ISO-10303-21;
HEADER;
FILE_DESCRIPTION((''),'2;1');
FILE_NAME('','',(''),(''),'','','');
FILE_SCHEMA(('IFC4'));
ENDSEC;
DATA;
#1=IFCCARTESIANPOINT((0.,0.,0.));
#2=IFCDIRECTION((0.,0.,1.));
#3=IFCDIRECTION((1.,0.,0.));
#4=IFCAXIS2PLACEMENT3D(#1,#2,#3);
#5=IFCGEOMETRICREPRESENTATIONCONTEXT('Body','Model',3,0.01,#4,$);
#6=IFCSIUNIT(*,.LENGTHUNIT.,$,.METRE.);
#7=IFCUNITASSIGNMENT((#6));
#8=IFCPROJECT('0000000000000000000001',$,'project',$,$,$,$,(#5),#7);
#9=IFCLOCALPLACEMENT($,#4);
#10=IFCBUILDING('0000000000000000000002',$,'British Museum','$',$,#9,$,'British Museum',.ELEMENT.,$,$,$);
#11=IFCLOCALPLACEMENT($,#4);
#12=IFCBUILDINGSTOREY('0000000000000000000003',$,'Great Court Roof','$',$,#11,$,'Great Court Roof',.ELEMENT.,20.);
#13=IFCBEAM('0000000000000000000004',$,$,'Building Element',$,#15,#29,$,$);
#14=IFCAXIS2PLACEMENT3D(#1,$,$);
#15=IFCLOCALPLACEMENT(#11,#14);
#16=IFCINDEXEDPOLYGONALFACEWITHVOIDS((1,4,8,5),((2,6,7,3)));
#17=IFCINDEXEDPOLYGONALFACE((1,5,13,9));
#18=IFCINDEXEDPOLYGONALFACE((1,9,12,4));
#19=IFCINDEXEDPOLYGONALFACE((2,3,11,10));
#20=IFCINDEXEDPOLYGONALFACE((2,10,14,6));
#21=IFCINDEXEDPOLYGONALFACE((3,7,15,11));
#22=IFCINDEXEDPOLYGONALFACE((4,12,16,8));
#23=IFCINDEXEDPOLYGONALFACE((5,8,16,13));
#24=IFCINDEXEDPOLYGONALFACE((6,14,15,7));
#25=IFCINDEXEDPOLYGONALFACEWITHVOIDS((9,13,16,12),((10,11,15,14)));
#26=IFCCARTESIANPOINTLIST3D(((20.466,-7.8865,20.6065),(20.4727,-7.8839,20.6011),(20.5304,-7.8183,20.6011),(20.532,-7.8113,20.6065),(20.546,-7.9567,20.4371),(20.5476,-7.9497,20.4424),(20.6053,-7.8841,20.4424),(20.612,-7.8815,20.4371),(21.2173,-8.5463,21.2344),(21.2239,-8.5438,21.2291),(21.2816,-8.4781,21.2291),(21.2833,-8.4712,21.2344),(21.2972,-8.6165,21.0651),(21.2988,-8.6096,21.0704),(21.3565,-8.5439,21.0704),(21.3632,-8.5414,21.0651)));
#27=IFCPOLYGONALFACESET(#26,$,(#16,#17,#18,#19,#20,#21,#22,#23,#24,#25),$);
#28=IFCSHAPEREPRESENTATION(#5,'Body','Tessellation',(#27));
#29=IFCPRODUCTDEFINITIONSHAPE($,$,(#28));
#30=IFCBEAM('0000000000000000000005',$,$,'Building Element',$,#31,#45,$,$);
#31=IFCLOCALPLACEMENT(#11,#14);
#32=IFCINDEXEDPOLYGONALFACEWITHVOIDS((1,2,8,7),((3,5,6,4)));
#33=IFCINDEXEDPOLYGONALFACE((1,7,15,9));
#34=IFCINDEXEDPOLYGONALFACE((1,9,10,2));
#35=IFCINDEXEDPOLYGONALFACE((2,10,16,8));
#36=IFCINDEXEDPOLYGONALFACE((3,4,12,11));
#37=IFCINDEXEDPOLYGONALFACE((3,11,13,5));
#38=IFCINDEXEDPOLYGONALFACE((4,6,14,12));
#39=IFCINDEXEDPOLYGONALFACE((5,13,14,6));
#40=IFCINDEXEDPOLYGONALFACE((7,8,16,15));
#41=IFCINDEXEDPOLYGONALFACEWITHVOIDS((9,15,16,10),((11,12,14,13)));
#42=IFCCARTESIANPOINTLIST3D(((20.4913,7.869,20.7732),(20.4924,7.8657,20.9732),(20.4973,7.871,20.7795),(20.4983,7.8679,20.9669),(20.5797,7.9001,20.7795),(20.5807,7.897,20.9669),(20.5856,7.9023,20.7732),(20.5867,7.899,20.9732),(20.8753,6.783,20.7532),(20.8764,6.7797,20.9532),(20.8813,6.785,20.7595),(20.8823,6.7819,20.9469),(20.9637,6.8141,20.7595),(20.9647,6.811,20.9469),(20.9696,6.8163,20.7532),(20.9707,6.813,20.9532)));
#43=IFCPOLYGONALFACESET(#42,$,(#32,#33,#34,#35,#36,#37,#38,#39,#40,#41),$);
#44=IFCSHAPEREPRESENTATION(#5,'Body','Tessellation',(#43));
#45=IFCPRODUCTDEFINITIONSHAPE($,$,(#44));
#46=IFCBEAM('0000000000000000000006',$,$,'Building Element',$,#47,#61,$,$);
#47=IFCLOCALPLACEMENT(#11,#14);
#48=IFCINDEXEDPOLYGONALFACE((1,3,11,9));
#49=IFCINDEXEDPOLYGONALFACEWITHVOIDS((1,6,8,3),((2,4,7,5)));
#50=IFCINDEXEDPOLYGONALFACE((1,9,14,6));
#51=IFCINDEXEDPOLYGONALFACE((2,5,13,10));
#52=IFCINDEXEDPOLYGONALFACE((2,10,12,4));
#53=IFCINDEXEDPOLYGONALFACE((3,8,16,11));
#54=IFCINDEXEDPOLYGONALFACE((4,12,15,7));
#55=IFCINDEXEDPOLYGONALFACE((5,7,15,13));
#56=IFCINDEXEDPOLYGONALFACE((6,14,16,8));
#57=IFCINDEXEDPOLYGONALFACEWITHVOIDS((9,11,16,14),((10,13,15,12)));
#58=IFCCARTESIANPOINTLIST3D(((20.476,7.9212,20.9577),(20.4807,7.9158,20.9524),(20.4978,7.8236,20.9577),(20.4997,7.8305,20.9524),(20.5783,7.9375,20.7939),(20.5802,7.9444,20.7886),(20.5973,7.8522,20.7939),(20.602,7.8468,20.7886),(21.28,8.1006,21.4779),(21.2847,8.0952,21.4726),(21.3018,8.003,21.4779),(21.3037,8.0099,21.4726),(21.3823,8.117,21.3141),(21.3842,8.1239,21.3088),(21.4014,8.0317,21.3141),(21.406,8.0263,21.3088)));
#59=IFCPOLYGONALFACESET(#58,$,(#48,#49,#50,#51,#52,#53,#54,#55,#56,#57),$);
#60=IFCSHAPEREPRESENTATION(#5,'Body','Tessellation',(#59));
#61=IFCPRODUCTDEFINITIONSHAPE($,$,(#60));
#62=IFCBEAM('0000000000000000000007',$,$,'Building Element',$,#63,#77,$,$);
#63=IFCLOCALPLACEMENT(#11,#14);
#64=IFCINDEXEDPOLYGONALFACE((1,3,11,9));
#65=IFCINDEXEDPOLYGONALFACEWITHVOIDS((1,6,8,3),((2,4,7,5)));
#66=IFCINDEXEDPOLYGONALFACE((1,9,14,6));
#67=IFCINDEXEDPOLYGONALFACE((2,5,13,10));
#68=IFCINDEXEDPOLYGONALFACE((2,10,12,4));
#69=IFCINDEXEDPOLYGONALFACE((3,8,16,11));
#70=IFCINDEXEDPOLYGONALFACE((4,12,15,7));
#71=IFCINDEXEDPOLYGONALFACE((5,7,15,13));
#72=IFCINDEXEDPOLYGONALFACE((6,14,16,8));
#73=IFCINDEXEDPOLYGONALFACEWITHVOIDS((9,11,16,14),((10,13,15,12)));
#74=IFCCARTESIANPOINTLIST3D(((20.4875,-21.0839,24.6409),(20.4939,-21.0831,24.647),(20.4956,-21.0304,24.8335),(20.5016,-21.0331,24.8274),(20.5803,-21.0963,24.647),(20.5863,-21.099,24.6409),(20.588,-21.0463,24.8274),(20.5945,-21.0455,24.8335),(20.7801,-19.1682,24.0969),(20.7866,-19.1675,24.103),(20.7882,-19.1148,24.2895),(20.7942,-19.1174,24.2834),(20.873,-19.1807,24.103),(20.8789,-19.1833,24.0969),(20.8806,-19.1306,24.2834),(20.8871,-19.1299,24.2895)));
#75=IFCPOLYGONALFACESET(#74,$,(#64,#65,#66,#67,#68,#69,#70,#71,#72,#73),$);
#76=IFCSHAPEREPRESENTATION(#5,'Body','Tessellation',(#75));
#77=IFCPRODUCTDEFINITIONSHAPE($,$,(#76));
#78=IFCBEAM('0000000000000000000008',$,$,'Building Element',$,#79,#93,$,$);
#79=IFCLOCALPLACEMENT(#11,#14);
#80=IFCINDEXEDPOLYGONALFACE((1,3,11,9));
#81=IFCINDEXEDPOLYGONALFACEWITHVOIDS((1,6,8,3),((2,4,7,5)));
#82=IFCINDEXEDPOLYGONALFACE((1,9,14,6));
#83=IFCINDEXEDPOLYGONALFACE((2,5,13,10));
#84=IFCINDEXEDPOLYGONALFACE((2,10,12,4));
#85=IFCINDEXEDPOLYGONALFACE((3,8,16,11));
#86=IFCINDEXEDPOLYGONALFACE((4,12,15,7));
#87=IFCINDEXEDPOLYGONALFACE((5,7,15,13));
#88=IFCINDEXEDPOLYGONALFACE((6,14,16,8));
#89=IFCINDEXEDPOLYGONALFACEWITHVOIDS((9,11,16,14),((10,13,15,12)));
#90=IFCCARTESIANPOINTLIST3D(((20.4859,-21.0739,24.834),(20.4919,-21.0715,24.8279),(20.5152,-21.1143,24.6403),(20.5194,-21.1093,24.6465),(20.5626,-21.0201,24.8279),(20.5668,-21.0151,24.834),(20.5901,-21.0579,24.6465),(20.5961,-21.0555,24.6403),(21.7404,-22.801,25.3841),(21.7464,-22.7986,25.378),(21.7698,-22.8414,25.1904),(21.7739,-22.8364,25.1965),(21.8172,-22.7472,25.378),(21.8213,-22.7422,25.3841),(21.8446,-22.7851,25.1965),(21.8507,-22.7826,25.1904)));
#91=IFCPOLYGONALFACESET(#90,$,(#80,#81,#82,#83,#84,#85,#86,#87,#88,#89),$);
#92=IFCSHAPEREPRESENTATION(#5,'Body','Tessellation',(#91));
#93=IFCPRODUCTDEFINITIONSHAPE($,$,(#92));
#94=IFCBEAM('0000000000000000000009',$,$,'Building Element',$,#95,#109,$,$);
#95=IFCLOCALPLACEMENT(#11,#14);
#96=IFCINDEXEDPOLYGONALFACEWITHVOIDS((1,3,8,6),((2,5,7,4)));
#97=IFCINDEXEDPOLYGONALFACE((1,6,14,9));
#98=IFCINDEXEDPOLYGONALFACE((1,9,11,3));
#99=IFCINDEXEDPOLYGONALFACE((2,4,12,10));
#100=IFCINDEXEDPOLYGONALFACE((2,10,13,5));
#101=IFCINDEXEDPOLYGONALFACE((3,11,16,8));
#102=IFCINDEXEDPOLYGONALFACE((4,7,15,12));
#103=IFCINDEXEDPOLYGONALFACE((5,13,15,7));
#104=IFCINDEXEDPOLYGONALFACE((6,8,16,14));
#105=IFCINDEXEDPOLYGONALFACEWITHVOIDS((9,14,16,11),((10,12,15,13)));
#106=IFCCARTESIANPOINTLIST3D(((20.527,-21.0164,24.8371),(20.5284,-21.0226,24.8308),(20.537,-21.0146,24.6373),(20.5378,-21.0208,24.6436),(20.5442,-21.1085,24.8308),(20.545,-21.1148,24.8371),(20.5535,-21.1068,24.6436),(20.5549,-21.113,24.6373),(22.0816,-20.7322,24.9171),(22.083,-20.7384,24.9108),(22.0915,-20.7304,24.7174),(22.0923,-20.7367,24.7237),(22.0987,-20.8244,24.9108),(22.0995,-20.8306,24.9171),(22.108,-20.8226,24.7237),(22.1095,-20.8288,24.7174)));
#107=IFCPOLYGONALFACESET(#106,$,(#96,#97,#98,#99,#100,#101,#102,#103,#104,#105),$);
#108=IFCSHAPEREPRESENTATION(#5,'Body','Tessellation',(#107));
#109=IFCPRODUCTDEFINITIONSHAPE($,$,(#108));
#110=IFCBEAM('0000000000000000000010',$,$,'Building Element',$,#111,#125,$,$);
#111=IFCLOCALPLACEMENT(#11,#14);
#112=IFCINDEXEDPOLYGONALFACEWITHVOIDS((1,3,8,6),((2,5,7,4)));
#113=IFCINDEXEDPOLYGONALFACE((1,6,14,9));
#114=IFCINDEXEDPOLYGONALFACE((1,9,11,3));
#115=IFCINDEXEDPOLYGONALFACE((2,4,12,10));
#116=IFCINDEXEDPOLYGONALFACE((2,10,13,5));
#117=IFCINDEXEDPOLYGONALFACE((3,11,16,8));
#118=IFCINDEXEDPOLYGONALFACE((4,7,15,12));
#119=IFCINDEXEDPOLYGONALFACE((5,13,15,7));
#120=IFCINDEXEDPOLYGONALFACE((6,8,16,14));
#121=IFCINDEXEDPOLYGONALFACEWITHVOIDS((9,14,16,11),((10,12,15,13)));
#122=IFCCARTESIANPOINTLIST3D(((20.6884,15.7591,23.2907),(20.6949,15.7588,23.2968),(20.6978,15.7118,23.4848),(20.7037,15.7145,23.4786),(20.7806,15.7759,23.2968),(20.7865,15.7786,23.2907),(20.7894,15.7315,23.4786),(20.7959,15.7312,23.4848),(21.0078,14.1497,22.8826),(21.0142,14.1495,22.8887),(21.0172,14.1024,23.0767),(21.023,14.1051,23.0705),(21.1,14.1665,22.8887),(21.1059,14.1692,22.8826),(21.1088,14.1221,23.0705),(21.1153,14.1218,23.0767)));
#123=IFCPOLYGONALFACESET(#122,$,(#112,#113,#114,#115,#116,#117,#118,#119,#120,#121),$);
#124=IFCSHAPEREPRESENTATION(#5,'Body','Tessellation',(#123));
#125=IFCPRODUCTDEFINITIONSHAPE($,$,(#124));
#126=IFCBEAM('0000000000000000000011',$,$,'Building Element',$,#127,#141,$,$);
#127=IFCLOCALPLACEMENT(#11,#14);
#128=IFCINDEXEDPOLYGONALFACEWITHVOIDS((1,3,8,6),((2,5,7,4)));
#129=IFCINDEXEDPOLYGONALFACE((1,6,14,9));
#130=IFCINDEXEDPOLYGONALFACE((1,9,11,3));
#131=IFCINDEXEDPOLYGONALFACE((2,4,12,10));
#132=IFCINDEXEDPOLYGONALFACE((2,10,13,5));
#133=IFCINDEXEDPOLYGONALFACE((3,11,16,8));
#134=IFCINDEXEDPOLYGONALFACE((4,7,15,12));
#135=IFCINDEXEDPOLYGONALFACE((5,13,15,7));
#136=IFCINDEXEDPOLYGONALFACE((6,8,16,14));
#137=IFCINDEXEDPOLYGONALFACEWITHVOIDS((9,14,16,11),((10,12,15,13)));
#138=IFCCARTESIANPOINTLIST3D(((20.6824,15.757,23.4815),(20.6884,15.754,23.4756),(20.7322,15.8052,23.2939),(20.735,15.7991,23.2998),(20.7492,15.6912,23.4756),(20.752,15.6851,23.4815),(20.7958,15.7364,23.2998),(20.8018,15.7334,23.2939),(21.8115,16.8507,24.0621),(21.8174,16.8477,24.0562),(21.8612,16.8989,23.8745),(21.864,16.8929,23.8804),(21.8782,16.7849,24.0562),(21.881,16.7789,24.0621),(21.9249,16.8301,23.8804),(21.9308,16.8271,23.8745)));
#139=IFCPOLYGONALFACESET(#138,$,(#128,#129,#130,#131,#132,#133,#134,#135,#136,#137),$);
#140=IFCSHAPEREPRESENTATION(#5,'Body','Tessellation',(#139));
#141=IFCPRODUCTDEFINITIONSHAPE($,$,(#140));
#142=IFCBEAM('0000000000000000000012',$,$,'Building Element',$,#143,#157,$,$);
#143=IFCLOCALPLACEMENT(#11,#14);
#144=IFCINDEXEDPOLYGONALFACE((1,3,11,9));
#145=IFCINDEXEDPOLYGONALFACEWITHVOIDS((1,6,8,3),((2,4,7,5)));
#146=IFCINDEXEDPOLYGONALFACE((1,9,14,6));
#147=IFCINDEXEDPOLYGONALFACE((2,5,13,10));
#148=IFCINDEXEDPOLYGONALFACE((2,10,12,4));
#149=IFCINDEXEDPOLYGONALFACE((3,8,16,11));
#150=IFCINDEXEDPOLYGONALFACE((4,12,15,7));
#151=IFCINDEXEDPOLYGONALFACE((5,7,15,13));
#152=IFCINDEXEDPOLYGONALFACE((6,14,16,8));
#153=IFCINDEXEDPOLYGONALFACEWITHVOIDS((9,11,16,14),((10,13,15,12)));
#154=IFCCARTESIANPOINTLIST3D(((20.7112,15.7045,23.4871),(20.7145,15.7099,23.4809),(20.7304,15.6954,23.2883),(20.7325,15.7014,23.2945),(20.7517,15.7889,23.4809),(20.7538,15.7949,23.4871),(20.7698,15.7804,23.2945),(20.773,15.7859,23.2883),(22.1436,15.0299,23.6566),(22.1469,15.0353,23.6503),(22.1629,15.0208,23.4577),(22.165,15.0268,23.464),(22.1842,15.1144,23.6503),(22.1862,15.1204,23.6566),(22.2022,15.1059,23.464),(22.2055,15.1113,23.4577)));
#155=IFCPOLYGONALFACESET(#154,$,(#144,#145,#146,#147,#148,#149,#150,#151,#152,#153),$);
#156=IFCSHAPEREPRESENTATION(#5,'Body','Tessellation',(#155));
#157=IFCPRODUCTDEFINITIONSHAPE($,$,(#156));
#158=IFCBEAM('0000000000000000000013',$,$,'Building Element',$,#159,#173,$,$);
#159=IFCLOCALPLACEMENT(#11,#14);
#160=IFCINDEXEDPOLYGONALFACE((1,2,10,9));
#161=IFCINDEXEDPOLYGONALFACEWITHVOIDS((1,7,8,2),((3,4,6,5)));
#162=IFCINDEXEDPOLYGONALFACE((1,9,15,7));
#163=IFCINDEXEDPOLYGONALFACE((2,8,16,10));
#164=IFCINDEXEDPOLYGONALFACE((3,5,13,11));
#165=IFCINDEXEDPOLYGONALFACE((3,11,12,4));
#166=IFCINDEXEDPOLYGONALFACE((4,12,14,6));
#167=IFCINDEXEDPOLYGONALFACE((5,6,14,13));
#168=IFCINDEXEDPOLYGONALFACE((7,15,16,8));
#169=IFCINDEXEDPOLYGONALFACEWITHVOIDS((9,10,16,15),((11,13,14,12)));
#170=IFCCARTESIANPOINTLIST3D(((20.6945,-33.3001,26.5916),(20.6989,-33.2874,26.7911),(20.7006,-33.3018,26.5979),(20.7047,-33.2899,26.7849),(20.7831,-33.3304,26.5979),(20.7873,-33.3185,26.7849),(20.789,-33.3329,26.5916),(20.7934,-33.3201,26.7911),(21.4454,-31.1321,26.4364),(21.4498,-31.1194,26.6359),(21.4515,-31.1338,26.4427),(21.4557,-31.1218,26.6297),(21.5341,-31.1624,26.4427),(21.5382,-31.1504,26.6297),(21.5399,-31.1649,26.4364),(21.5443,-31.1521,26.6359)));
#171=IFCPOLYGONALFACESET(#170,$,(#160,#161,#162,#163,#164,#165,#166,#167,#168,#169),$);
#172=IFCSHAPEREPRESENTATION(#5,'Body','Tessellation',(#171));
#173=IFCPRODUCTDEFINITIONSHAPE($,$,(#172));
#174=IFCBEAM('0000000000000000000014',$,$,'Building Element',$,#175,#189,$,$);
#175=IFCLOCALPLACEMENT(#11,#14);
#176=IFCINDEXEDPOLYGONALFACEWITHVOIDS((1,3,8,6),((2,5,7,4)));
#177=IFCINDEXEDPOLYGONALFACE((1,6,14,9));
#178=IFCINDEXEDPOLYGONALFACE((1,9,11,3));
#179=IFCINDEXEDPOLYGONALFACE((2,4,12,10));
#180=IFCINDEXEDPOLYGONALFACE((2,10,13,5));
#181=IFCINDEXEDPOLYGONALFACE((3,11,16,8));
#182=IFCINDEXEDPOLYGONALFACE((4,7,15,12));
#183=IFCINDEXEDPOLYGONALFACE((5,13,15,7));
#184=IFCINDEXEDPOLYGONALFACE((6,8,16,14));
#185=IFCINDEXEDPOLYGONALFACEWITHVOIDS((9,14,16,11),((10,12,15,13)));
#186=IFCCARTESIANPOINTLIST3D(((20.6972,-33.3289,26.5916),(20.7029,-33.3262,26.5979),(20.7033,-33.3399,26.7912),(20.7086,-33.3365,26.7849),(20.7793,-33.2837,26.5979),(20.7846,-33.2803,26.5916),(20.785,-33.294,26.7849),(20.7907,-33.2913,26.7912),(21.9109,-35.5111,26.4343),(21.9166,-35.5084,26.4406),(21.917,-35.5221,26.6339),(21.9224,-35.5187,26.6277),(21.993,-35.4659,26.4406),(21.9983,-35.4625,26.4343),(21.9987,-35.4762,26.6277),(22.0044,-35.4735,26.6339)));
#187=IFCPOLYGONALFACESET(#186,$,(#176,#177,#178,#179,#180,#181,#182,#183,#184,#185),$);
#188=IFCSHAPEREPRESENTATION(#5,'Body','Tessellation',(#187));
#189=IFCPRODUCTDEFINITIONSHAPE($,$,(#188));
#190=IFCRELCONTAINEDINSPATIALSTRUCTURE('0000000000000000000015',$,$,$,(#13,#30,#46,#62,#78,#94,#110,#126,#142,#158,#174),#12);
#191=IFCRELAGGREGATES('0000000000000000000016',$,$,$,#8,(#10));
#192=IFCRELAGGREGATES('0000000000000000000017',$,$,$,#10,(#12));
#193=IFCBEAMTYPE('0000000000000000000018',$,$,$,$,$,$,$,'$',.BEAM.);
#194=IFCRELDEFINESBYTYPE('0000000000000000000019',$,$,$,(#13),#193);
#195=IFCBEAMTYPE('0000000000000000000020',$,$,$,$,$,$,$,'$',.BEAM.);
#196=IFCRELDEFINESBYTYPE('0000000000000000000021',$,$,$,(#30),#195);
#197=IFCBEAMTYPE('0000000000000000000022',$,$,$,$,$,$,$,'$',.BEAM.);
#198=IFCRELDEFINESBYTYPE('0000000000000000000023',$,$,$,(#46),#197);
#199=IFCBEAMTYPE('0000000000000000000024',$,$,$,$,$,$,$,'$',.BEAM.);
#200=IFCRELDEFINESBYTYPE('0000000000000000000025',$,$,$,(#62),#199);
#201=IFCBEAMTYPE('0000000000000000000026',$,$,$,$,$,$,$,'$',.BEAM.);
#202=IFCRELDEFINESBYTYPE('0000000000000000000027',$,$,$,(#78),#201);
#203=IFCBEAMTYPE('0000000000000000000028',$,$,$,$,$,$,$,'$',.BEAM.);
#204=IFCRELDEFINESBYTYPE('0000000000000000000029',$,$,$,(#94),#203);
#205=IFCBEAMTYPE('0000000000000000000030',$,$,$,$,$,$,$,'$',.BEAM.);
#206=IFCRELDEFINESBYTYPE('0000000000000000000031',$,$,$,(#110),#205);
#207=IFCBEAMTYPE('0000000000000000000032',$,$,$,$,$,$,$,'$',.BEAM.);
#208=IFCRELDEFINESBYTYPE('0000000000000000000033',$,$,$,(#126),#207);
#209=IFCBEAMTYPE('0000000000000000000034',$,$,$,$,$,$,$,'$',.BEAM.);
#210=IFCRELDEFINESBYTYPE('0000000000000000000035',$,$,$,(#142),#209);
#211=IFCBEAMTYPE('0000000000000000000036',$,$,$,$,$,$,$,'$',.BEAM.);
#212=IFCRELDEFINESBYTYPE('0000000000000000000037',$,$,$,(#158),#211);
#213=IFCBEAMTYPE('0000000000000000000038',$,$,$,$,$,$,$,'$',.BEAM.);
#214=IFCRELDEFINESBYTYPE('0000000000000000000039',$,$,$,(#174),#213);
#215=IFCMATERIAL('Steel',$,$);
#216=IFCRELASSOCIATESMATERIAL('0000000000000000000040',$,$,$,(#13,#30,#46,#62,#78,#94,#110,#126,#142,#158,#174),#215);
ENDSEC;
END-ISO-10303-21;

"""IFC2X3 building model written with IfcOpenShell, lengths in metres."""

from ifc_helpers import new_model, si_unit, frame, origin_with_axes, origin_2d, place, context, project, spatial, hollow_rectangle, extrude, material, type_object, element, save


model = new_model("IFC2X3")

# Units and contexts
model_context = context("Model", 3, precision=0.01, world=origin_with_axes(), identifier="Body")
ifc_project = project(units=[si_unit("LENGTHUNIT", "METRE")], contexts=[model_context])

# Building, storey
building_placement = place(None, origin_with_axes())
building = spatial("IfcBuilding", under=ifc_project, at=building_placement, Name="British Museum", Description="$", LongName="British Museum", CompositionType="ELEMENT")
storey_placement = place(None, origin_with_axes())
storey = spatial("IfcBuildingStorey", under=building, at=storey_placement, Name="Great Court Roof", Description="$", LongName="Great Court Roof", CompositionType="ELEMENT", Elevation=20.0)

# Beams
ifc_material = material(Name="Steel")
beam_type_1 = type_object("IfcBeamType", ElementType="$", PredefinedType="BEAM")
beam_1_placement = place(None, origin_with_axes())
element("IfcBeam", 1, at=beam_1_placement, inside=storey, type_object=beam_type_1, material=ifc_material, Description="Building Element", context=model_context, shape_type="SweptSolid", body=[
    extrude(hollow_rectangle(XDim=0.1, YDim=0.2, WallThickness=0.0063, InnerFilletRadius=-0.0063, OuterFilletRadius=0.0, at=origin_2d()), frame((20.539, -7.884, 20.5218), z_axis=(0.63625, -0.558852, 0.531855), x_axis=(0.65993, 0.751327, 0.0)), (0.0, 0.0, 1.0), 1.1807),
])
beam_type_2 = type_object("IfcBeamType", ElementType="$", PredefinedType="BEAM")
beam_2_placement = place(None, origin_with_axes())
element("IfcBeam", 2, at=beam_2_placement, inside=storey, type_object=beam_type_2, material=ifc_material, Description="Building Element", context=model_context, shape_type="SweptSolid", body=[
    extrude(hollow_rectangle(XDim=0.1, YDim=0.2, WallThickness=0.0063, InnerFilletRadius=-0.0063, OuterFilletRadius=0.0, at=origin_2d()), frame((20.539, 7.884, 20.8732), z_axis=(0.333315, -0.942656, -0.017338), x_axis=(0.942798, 0.333365, 0.0)), (0.0, 0.0, 1.0), 1.1521),
])
beam_type_3 = type_object("IfcBeamType", ElementType="$", PredefinedType="BEAM")
beam_3_placement = place(None, origin_with_axes())
element("IfcBeam", 3, at=beam_3_placement, inside=storey, type_object=beam_type_3, material=ifc_material, Description="Building Element", context=model_context, shape_type="SweptSolid", body=[
    extrude(hollow_rectangle(XDim=0.1, YDim=0.2, WallThickness=0.0063, InnerFilletRadius=-0.0063, OuterFilletRadius=0.0, at=origin_2d()), frame((20.539, 7.884, 20.8732), z_axis=(0.825235, 0.18417, 0.533918), x_axis=(-0.217814, 0.97599, 0.0)), (0.0, 0.0, 1.0), 0.9743),
])
beam_type_4 = type_object("IfcBeamType", ElementType="$", PredefinedType="BEAM")
beam_4_placement = place(None, origin_with_axes())
element("IfcBeam", 4, at=beam_4_placement, inside=storey, type_object=beam_type_4, material=ifc_material, Description="Building Element", context=model_context, shape_type="SweptSolid", body=[
    extrude(hollow_rectangle(XDim=0.1, YDim=0.2, WallThickness=0.0063, InnerFilletRadius=-0.0063, OuterFilletRadius=0.0, at=origin_2d()), frame((20.541, -21.0647, 24.7372), z_axis=(0.145382, 0.951744, -0.270274), x_axis=(-0.988533, 0.151002, 0.0)), (0.0, 0.0, 1.0), 2.0127),
])
beam_type_5 = type_object("IfcBeamType", ElementType="$", PredefinedType="BEAM")
beam_5_placement = place(None, origin_with_axes())
element("IfcBeam", 5, at=beam_5_placement, inside=storey, type_object=beam_type_5, material=ifc_material, Description="Building Element", context=model_context, shape_type="SweptSolid", body=[
    extrude(hollow_rectangle(XDim=0.1, YDim=0.2, WallThickness=0.0063, InnerFilletRadius=-0.0063, OuterFilletRadius=0.0, at=origin_2d()), frame((20.541, -21.0647, 24.7372), z_axis=(0.569112, -0.783482, 0.249536), x_axis=(0.809076, 0.587704, 0.0)), (0.0, 0.0, 1.0), 2.2044),
])
beam_type_6 = type_object("IfcBeamType", ElementType="$", PredefinedType="BEAM")
beam_6_placement = place(None, origin_with_axes())
element("IfcBeam", 6, at=beam_6_placement, inside=storey, type_object=beam_type_6, material=ifc_material, Description="Building Element", context=model_context, shape_type="SweptSolid", body=[
    extrude(hollow_rectangle(XDim=0.1, YDim=0.2, WallThickness=0.0063, InnerFilletRadius=-0.0063, OuterFilletRadius=0.0, at=origin_2d()), frame((20.541, -21.0647, 24.7372), z_axis=(0.982439, 0.179593, 0.0506), x_axis=(-0.179823, 0.983699, 0.0)), (0.0, 0.0, 1.0), 1.5823),
])
beam_type_7 = type_object("IfcBeamType", ElementType="$", PredefinedType="BEAM")
beam_7_placement = place(None, origin_with_axes())
element("IfcBeam", 7, at=beam_7_placement, inside=storey, type_object=beam_type_7, material=ifc_material, Description="Building Element", context=model_context, shape_type="SweptSolid", body=[
    extrude(hollow_rectangle(XDim=0.1, YDim=0.2, WallThickness=0.0063, InnerFilletRadius=-0.0063, OuterFilletRadius=0.0, at=origin_2d()), frame((20.7421, 15.7452, 23.3877), z_axis=(0.188904, -0.951869, -0.241372), x_axis=(0.980871, 0.194659, 0.0)), (0.0, 0.0, 1.0), 1.6908),
])
beam_type_8 = type_object("IfcBeamType", ElementType="$", PredefinedType="BEAM")
beam_8_placement = place(None, origin_with_axes())
element("IfcBeam", 8, at=beam_8_placement, inside=storey, type_object=beam_type_8, material=ifc_material, Description="Building Element", context=model_context, shape_type="SweptSolid", body=[
    extrude(hollow_rectangle(XDim=0.1, YDim=0.2, WallThickness=0.0063, InnerFilletRadius=-0.0063, OuterFilletRadius=0.0, at=origin_2d()), frame((20.7421, 15.7452, 23.3877), z_axis=(0.673754, 0.652701, 0.346464), x_axis=(-0.695796, 0.718239, 0.0)), (0.0, 0.0, 1.0), 1.6757),
])
beam_type_9 = type_object("IfcBeamType", ElementType="$", PredefinedType="BEAM")
beam_9_placement = place(None, origin_with_axes())
element("IfcBeam", 9, at=beam_9_placement, inside=storey, type_object=beam_type_9, material=ifc_material, Description="Building Element", context=model_context, shape_type="SweptSolid", body=[
    extrude(hollow_rectangle(XDim=0.1, YDim=0.2, WallThickness=0.0063, InnerFilletRadius=-0.0063, OuterFilletRadius=0.0, at=origin_2d()), frame((20.7421, 15.7452, 23.3877), z_axis=(0.89957, -0.42362, 0.106398), x_axis=(0.426039, 0.904705, 0.0)), (0.0, 0.0, 1.0), 1.5924),
])
beam_type_10 = type_object("IfcBeamType", ElementType="$", PredefinedType="BEAM")
beam_10_placement = place(None, origin_with_axes())
element("IfcBeam", 10, at=beam_10_placement, inside=storey, type_object=beam_type_10, material=ifc_material, Description="Building Element", context=model_context, shape_type="SweptSolid", body=[
    extrude(hollow_rectangle(XDim=0.1, YDim=0.2, WallThickness=0.0063, InnerFilletRadius=-0.0063, OuterFilletRadius=0.0, at=origin_2d()), frame((20.7439, -33.3101, 26.6914), z_axis=(0.326554, 0.942766, -0.067491), x_axis=(-0.944921, 0.3273, 0.0)), (0.0, 0.0, 1.0), 2.2996),
])
beam_type_11 = type_object("IfcBeamType", ElementType="$", PredefinedType="BEAM")
beam_11_placement = place(None, origin_with_axes())
element("IfcBeam", 11, at=beam_11_placement, inside=storey, type_object=beam_type_11, material=ifc_material, Description="Building Element", context=model_context, shape_type="SweptSolid", body=[
    extrude(hollow_rectangle(XDim=0.1, YDim=0.2, WallThickness=0.0063, InnerFilletRadius=-0.0063, OuterFilletRadius=0.0, at=origin_2d()), frame((20.7439, -33.3101, 26.6914), z_axis=(0.48512, -0.872187, -0.062845), x_axis=(0.873914, 0.48608, 0.0)), (0.0, 0.0, 1.0), 2.502),
])

save(model, "model.ifc")
